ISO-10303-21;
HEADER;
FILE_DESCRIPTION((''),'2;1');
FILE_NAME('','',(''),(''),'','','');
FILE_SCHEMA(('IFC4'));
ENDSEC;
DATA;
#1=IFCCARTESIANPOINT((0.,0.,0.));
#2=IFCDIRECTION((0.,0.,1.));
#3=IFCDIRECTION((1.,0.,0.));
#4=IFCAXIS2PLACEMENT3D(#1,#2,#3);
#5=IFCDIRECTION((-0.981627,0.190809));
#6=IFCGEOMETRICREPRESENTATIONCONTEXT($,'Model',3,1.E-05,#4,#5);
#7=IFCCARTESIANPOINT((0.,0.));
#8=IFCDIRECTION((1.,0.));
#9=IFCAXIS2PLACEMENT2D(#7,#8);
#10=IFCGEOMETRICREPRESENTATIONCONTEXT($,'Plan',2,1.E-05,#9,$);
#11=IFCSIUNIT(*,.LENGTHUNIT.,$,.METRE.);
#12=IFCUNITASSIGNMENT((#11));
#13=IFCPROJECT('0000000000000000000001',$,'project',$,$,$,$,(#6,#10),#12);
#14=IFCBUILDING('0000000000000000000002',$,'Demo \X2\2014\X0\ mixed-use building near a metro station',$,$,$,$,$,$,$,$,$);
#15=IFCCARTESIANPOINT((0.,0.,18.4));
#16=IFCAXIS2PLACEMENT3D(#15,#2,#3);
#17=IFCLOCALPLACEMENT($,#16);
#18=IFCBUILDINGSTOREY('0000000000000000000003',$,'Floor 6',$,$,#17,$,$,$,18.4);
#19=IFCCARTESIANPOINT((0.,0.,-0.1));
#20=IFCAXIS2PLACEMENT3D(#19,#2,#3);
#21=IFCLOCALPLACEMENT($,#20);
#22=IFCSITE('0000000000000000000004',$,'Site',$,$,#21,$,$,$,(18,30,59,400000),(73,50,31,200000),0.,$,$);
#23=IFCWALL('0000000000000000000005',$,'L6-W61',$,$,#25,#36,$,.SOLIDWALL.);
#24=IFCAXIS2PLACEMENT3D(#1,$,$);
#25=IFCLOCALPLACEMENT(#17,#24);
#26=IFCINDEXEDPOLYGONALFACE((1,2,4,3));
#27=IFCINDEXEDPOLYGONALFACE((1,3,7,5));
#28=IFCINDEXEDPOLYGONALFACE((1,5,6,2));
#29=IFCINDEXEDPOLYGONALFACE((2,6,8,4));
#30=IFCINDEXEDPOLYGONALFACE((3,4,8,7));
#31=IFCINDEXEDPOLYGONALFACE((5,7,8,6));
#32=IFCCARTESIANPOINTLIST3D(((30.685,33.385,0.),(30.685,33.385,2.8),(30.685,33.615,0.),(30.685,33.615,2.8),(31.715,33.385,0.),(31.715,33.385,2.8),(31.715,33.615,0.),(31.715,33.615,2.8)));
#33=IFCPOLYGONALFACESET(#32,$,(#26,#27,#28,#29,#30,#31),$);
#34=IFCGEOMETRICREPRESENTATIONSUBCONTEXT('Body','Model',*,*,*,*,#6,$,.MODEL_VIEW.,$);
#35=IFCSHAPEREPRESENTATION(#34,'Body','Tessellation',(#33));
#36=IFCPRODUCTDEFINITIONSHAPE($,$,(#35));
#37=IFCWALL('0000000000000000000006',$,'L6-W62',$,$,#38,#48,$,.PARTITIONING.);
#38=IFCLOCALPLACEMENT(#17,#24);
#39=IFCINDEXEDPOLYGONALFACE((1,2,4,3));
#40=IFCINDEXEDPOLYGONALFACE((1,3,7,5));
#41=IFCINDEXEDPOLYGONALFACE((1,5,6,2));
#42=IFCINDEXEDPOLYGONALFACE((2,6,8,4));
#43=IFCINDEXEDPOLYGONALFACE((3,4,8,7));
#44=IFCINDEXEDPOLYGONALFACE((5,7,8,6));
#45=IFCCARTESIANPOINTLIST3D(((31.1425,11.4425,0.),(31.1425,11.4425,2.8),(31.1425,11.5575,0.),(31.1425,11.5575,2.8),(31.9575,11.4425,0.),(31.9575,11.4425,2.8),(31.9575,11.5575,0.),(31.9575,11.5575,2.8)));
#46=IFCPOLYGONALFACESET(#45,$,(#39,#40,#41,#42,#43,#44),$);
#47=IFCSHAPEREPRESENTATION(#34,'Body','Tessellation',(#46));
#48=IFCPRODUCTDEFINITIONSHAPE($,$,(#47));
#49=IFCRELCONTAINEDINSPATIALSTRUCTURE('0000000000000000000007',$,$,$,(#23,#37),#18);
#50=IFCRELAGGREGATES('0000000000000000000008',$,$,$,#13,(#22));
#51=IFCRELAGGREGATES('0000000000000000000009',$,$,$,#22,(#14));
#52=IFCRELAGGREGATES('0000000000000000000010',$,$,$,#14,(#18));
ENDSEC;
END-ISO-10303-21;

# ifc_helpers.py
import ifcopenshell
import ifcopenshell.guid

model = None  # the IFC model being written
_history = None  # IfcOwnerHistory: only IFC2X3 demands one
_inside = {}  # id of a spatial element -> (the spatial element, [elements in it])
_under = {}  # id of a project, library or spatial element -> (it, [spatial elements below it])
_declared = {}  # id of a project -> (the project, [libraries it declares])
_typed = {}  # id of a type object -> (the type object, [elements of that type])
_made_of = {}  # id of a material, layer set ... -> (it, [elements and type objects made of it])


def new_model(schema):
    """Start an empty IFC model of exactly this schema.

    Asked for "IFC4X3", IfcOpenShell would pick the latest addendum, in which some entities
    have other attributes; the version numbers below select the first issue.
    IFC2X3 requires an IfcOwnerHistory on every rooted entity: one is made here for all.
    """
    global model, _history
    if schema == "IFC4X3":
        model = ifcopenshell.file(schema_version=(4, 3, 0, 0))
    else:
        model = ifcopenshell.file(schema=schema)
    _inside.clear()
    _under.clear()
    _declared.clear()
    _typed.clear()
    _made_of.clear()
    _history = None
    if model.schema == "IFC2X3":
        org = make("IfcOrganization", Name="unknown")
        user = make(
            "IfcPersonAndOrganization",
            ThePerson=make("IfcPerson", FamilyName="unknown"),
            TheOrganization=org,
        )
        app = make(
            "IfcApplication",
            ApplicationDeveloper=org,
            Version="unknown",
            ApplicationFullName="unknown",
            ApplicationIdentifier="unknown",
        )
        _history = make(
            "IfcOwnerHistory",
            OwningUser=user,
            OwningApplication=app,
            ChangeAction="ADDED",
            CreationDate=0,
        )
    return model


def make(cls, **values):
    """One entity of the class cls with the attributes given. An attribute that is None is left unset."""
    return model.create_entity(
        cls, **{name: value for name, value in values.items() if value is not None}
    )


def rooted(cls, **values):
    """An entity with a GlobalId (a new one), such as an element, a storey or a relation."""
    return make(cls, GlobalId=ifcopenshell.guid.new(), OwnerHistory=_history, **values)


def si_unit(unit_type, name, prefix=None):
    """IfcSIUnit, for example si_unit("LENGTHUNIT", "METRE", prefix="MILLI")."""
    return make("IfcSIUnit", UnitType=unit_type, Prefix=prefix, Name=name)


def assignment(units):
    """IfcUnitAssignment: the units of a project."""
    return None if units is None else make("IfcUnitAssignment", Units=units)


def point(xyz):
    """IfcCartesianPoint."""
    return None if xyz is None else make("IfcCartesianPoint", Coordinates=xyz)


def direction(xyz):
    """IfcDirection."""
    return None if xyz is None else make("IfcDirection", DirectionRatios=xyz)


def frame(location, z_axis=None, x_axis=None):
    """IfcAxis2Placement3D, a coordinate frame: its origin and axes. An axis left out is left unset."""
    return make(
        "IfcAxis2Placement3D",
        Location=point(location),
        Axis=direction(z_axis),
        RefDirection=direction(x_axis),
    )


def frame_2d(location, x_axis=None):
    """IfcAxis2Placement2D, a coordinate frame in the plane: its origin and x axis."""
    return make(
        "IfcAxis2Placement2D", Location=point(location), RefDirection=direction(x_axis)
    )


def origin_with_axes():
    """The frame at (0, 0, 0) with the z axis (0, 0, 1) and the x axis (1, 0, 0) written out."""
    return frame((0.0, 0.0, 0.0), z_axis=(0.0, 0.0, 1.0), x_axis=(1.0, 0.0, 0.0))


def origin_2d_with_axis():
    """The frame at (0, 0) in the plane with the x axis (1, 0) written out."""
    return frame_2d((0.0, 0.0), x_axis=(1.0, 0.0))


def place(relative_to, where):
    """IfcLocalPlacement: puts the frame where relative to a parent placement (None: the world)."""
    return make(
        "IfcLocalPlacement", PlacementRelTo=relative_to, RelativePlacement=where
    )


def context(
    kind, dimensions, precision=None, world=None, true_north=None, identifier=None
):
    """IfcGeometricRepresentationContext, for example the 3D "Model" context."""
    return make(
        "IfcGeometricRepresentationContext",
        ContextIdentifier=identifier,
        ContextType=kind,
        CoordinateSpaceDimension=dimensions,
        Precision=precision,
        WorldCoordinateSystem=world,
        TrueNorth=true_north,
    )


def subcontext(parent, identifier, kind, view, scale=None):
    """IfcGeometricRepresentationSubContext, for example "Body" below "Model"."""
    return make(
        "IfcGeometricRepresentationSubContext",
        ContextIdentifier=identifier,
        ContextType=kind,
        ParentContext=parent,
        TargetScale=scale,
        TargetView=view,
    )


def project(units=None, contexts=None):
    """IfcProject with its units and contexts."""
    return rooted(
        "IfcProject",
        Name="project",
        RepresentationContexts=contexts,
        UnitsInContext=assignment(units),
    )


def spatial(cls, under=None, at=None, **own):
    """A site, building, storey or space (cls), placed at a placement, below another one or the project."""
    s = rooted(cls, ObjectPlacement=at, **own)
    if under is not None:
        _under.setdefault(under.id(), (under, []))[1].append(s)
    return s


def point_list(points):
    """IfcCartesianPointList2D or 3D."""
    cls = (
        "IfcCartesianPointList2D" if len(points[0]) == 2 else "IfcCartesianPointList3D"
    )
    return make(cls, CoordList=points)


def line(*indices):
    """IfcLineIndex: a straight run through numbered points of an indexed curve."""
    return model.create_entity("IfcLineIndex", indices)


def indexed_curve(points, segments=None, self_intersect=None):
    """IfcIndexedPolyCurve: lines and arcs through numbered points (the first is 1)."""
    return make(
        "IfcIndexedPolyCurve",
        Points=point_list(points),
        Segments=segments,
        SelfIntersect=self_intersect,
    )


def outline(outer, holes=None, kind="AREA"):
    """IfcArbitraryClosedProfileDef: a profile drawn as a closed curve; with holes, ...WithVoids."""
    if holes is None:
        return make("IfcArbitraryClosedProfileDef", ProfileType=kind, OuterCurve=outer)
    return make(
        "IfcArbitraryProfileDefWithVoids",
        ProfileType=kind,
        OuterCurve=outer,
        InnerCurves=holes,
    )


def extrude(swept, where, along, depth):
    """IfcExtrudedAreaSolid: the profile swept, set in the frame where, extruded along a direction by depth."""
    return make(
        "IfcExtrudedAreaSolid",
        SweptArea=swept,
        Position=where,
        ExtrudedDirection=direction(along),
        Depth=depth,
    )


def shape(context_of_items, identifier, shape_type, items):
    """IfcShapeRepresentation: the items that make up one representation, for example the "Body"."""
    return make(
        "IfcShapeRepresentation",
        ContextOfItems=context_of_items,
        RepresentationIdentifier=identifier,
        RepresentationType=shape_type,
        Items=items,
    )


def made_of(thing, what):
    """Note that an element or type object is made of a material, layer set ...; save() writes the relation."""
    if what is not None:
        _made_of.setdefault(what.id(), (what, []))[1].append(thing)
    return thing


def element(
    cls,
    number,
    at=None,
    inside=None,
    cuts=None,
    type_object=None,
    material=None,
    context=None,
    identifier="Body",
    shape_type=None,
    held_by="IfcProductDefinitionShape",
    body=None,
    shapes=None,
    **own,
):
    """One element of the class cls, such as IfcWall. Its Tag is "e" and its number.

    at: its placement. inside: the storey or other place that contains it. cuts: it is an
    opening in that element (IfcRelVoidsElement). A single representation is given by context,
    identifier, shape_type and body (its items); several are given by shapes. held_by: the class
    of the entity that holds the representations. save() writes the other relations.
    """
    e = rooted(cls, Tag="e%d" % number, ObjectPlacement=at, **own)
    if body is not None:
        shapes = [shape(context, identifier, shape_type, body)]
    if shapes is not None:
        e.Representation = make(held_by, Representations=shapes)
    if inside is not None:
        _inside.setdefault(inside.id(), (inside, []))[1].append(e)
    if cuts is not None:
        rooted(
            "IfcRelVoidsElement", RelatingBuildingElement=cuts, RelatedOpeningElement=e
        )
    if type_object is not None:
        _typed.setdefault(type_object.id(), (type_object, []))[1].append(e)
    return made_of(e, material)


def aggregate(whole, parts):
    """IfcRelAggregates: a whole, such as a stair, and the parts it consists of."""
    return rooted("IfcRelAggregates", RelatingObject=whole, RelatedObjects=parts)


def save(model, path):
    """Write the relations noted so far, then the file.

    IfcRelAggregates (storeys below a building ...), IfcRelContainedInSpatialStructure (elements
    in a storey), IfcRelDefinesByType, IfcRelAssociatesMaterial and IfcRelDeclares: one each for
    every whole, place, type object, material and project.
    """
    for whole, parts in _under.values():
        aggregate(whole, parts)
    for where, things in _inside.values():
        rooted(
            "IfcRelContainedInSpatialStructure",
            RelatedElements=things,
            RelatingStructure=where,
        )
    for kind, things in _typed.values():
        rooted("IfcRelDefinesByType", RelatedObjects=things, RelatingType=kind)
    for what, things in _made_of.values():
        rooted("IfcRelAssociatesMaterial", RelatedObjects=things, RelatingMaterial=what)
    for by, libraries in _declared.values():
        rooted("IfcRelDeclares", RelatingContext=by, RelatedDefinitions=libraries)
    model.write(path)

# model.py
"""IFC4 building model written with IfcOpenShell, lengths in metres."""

from ifc_helpers import new_model, si_unit, direction, frame, origin_with_axes, origin_2d_with_axis, place, context, subcontext, project, spatial, line, indexed_curve, outline, extrude, element, save


model = new_model("IFC4")

# Units and contexts
model_context = context("Model", 3, precision=1e-05, world=origin_with_axes(), true_north=direction((-0.981627, 0.190809)))
plan_context = context("Plan", 2, precision=1e-05, world=origin_2d_with_axis())
body_context = subcontext(model_context, "Body", "Model", "MODEL_VIEW")
ifc_project = project(units=[si_unit("LENGTHUNIT", "METRE")], contexts=[model_context, plan_context])

# Site, building, storey
site_placement = place(None, frame((0.0, 0.0, -0.1), z_axis=(0.0, 0.0, 1.0), x_axis=(1.0, 0.0, 0.0)))
site = spatial("IfcSite", under=ifc_project, at=site_placement, Name="Site", RefLatitude=(18, 30, 59, 400000), RefLongitude=(73, 50, 31, 200000), RefElevation=0.0)
building = spatial("IfcBuilding", under=site, Name="Demo — mixed-use building near a metro station")
storey_placement = place(None, frame((0.0, 0.0, 18.4), z_axis=(0.0, 0.0, 1.0), x_axis=(1.0, 0.0, 0.0)))
storey = spatial("IfcBuildingStorey", under=building, at=storey_placement, Name="Floor 6", Elevation=18.4)

# Walls
wall_1_placement = place(storey_placement, frame((0.0, 0.0, -18.4), z_axis=(0.0, 0.0, 1.0), x_axis=(1.0, 0.0, 0.0)))
element("IfcWall", 1, at=wall_1_placement, inside=storey, Name="L6-W61", PredefinedType="SOLIDWALL", context=body_context, shape_type="SweptSolid", body=[
    extrude(outline(indexed_curve([(31.715, 33.385), (30.685, 33.385), (30.685, 33.615), (31.715, 33.615)], segments=[line(1, 2, 3, 4, 1)])), frame((0.0, 0.0, 18.4), z_axis=(0.0, 0.0, 1.0), x_axis=(1.0, 0.0, 0.0)), (0.0, 0.0, 1.0), 2.8),
])
wall_2_placement = place(storey_placement, frame((0.0, 0.0, -18.4), z_axis=(0.0, 0.0, 1.0), x_axis=(1.0, 0.0, 0.0)))
element("IfcWall", 2, at=wall_2_placement, inside=storey, Name="L6-W62", PredefinedType="PARTITIONING", context=body_context, shape_type="SweptSolid", body=[
    extrude(outline(indexed_curve([(31.1425, 11.5575), (31.9575, 11.5575), (31.9575, 11.4425), (31.1425, 11.4425)], segments=[line(1, 2, 3, 4, 1)])), frame((0.0, 0.0, 18.4), z_axis=(0.0, 0.0, 1.0), x_axis=(1.0, 0.0, 0.0)), (0.0, 0.0, 1.0), 2.8),
])

save(model, "model.ifc")
